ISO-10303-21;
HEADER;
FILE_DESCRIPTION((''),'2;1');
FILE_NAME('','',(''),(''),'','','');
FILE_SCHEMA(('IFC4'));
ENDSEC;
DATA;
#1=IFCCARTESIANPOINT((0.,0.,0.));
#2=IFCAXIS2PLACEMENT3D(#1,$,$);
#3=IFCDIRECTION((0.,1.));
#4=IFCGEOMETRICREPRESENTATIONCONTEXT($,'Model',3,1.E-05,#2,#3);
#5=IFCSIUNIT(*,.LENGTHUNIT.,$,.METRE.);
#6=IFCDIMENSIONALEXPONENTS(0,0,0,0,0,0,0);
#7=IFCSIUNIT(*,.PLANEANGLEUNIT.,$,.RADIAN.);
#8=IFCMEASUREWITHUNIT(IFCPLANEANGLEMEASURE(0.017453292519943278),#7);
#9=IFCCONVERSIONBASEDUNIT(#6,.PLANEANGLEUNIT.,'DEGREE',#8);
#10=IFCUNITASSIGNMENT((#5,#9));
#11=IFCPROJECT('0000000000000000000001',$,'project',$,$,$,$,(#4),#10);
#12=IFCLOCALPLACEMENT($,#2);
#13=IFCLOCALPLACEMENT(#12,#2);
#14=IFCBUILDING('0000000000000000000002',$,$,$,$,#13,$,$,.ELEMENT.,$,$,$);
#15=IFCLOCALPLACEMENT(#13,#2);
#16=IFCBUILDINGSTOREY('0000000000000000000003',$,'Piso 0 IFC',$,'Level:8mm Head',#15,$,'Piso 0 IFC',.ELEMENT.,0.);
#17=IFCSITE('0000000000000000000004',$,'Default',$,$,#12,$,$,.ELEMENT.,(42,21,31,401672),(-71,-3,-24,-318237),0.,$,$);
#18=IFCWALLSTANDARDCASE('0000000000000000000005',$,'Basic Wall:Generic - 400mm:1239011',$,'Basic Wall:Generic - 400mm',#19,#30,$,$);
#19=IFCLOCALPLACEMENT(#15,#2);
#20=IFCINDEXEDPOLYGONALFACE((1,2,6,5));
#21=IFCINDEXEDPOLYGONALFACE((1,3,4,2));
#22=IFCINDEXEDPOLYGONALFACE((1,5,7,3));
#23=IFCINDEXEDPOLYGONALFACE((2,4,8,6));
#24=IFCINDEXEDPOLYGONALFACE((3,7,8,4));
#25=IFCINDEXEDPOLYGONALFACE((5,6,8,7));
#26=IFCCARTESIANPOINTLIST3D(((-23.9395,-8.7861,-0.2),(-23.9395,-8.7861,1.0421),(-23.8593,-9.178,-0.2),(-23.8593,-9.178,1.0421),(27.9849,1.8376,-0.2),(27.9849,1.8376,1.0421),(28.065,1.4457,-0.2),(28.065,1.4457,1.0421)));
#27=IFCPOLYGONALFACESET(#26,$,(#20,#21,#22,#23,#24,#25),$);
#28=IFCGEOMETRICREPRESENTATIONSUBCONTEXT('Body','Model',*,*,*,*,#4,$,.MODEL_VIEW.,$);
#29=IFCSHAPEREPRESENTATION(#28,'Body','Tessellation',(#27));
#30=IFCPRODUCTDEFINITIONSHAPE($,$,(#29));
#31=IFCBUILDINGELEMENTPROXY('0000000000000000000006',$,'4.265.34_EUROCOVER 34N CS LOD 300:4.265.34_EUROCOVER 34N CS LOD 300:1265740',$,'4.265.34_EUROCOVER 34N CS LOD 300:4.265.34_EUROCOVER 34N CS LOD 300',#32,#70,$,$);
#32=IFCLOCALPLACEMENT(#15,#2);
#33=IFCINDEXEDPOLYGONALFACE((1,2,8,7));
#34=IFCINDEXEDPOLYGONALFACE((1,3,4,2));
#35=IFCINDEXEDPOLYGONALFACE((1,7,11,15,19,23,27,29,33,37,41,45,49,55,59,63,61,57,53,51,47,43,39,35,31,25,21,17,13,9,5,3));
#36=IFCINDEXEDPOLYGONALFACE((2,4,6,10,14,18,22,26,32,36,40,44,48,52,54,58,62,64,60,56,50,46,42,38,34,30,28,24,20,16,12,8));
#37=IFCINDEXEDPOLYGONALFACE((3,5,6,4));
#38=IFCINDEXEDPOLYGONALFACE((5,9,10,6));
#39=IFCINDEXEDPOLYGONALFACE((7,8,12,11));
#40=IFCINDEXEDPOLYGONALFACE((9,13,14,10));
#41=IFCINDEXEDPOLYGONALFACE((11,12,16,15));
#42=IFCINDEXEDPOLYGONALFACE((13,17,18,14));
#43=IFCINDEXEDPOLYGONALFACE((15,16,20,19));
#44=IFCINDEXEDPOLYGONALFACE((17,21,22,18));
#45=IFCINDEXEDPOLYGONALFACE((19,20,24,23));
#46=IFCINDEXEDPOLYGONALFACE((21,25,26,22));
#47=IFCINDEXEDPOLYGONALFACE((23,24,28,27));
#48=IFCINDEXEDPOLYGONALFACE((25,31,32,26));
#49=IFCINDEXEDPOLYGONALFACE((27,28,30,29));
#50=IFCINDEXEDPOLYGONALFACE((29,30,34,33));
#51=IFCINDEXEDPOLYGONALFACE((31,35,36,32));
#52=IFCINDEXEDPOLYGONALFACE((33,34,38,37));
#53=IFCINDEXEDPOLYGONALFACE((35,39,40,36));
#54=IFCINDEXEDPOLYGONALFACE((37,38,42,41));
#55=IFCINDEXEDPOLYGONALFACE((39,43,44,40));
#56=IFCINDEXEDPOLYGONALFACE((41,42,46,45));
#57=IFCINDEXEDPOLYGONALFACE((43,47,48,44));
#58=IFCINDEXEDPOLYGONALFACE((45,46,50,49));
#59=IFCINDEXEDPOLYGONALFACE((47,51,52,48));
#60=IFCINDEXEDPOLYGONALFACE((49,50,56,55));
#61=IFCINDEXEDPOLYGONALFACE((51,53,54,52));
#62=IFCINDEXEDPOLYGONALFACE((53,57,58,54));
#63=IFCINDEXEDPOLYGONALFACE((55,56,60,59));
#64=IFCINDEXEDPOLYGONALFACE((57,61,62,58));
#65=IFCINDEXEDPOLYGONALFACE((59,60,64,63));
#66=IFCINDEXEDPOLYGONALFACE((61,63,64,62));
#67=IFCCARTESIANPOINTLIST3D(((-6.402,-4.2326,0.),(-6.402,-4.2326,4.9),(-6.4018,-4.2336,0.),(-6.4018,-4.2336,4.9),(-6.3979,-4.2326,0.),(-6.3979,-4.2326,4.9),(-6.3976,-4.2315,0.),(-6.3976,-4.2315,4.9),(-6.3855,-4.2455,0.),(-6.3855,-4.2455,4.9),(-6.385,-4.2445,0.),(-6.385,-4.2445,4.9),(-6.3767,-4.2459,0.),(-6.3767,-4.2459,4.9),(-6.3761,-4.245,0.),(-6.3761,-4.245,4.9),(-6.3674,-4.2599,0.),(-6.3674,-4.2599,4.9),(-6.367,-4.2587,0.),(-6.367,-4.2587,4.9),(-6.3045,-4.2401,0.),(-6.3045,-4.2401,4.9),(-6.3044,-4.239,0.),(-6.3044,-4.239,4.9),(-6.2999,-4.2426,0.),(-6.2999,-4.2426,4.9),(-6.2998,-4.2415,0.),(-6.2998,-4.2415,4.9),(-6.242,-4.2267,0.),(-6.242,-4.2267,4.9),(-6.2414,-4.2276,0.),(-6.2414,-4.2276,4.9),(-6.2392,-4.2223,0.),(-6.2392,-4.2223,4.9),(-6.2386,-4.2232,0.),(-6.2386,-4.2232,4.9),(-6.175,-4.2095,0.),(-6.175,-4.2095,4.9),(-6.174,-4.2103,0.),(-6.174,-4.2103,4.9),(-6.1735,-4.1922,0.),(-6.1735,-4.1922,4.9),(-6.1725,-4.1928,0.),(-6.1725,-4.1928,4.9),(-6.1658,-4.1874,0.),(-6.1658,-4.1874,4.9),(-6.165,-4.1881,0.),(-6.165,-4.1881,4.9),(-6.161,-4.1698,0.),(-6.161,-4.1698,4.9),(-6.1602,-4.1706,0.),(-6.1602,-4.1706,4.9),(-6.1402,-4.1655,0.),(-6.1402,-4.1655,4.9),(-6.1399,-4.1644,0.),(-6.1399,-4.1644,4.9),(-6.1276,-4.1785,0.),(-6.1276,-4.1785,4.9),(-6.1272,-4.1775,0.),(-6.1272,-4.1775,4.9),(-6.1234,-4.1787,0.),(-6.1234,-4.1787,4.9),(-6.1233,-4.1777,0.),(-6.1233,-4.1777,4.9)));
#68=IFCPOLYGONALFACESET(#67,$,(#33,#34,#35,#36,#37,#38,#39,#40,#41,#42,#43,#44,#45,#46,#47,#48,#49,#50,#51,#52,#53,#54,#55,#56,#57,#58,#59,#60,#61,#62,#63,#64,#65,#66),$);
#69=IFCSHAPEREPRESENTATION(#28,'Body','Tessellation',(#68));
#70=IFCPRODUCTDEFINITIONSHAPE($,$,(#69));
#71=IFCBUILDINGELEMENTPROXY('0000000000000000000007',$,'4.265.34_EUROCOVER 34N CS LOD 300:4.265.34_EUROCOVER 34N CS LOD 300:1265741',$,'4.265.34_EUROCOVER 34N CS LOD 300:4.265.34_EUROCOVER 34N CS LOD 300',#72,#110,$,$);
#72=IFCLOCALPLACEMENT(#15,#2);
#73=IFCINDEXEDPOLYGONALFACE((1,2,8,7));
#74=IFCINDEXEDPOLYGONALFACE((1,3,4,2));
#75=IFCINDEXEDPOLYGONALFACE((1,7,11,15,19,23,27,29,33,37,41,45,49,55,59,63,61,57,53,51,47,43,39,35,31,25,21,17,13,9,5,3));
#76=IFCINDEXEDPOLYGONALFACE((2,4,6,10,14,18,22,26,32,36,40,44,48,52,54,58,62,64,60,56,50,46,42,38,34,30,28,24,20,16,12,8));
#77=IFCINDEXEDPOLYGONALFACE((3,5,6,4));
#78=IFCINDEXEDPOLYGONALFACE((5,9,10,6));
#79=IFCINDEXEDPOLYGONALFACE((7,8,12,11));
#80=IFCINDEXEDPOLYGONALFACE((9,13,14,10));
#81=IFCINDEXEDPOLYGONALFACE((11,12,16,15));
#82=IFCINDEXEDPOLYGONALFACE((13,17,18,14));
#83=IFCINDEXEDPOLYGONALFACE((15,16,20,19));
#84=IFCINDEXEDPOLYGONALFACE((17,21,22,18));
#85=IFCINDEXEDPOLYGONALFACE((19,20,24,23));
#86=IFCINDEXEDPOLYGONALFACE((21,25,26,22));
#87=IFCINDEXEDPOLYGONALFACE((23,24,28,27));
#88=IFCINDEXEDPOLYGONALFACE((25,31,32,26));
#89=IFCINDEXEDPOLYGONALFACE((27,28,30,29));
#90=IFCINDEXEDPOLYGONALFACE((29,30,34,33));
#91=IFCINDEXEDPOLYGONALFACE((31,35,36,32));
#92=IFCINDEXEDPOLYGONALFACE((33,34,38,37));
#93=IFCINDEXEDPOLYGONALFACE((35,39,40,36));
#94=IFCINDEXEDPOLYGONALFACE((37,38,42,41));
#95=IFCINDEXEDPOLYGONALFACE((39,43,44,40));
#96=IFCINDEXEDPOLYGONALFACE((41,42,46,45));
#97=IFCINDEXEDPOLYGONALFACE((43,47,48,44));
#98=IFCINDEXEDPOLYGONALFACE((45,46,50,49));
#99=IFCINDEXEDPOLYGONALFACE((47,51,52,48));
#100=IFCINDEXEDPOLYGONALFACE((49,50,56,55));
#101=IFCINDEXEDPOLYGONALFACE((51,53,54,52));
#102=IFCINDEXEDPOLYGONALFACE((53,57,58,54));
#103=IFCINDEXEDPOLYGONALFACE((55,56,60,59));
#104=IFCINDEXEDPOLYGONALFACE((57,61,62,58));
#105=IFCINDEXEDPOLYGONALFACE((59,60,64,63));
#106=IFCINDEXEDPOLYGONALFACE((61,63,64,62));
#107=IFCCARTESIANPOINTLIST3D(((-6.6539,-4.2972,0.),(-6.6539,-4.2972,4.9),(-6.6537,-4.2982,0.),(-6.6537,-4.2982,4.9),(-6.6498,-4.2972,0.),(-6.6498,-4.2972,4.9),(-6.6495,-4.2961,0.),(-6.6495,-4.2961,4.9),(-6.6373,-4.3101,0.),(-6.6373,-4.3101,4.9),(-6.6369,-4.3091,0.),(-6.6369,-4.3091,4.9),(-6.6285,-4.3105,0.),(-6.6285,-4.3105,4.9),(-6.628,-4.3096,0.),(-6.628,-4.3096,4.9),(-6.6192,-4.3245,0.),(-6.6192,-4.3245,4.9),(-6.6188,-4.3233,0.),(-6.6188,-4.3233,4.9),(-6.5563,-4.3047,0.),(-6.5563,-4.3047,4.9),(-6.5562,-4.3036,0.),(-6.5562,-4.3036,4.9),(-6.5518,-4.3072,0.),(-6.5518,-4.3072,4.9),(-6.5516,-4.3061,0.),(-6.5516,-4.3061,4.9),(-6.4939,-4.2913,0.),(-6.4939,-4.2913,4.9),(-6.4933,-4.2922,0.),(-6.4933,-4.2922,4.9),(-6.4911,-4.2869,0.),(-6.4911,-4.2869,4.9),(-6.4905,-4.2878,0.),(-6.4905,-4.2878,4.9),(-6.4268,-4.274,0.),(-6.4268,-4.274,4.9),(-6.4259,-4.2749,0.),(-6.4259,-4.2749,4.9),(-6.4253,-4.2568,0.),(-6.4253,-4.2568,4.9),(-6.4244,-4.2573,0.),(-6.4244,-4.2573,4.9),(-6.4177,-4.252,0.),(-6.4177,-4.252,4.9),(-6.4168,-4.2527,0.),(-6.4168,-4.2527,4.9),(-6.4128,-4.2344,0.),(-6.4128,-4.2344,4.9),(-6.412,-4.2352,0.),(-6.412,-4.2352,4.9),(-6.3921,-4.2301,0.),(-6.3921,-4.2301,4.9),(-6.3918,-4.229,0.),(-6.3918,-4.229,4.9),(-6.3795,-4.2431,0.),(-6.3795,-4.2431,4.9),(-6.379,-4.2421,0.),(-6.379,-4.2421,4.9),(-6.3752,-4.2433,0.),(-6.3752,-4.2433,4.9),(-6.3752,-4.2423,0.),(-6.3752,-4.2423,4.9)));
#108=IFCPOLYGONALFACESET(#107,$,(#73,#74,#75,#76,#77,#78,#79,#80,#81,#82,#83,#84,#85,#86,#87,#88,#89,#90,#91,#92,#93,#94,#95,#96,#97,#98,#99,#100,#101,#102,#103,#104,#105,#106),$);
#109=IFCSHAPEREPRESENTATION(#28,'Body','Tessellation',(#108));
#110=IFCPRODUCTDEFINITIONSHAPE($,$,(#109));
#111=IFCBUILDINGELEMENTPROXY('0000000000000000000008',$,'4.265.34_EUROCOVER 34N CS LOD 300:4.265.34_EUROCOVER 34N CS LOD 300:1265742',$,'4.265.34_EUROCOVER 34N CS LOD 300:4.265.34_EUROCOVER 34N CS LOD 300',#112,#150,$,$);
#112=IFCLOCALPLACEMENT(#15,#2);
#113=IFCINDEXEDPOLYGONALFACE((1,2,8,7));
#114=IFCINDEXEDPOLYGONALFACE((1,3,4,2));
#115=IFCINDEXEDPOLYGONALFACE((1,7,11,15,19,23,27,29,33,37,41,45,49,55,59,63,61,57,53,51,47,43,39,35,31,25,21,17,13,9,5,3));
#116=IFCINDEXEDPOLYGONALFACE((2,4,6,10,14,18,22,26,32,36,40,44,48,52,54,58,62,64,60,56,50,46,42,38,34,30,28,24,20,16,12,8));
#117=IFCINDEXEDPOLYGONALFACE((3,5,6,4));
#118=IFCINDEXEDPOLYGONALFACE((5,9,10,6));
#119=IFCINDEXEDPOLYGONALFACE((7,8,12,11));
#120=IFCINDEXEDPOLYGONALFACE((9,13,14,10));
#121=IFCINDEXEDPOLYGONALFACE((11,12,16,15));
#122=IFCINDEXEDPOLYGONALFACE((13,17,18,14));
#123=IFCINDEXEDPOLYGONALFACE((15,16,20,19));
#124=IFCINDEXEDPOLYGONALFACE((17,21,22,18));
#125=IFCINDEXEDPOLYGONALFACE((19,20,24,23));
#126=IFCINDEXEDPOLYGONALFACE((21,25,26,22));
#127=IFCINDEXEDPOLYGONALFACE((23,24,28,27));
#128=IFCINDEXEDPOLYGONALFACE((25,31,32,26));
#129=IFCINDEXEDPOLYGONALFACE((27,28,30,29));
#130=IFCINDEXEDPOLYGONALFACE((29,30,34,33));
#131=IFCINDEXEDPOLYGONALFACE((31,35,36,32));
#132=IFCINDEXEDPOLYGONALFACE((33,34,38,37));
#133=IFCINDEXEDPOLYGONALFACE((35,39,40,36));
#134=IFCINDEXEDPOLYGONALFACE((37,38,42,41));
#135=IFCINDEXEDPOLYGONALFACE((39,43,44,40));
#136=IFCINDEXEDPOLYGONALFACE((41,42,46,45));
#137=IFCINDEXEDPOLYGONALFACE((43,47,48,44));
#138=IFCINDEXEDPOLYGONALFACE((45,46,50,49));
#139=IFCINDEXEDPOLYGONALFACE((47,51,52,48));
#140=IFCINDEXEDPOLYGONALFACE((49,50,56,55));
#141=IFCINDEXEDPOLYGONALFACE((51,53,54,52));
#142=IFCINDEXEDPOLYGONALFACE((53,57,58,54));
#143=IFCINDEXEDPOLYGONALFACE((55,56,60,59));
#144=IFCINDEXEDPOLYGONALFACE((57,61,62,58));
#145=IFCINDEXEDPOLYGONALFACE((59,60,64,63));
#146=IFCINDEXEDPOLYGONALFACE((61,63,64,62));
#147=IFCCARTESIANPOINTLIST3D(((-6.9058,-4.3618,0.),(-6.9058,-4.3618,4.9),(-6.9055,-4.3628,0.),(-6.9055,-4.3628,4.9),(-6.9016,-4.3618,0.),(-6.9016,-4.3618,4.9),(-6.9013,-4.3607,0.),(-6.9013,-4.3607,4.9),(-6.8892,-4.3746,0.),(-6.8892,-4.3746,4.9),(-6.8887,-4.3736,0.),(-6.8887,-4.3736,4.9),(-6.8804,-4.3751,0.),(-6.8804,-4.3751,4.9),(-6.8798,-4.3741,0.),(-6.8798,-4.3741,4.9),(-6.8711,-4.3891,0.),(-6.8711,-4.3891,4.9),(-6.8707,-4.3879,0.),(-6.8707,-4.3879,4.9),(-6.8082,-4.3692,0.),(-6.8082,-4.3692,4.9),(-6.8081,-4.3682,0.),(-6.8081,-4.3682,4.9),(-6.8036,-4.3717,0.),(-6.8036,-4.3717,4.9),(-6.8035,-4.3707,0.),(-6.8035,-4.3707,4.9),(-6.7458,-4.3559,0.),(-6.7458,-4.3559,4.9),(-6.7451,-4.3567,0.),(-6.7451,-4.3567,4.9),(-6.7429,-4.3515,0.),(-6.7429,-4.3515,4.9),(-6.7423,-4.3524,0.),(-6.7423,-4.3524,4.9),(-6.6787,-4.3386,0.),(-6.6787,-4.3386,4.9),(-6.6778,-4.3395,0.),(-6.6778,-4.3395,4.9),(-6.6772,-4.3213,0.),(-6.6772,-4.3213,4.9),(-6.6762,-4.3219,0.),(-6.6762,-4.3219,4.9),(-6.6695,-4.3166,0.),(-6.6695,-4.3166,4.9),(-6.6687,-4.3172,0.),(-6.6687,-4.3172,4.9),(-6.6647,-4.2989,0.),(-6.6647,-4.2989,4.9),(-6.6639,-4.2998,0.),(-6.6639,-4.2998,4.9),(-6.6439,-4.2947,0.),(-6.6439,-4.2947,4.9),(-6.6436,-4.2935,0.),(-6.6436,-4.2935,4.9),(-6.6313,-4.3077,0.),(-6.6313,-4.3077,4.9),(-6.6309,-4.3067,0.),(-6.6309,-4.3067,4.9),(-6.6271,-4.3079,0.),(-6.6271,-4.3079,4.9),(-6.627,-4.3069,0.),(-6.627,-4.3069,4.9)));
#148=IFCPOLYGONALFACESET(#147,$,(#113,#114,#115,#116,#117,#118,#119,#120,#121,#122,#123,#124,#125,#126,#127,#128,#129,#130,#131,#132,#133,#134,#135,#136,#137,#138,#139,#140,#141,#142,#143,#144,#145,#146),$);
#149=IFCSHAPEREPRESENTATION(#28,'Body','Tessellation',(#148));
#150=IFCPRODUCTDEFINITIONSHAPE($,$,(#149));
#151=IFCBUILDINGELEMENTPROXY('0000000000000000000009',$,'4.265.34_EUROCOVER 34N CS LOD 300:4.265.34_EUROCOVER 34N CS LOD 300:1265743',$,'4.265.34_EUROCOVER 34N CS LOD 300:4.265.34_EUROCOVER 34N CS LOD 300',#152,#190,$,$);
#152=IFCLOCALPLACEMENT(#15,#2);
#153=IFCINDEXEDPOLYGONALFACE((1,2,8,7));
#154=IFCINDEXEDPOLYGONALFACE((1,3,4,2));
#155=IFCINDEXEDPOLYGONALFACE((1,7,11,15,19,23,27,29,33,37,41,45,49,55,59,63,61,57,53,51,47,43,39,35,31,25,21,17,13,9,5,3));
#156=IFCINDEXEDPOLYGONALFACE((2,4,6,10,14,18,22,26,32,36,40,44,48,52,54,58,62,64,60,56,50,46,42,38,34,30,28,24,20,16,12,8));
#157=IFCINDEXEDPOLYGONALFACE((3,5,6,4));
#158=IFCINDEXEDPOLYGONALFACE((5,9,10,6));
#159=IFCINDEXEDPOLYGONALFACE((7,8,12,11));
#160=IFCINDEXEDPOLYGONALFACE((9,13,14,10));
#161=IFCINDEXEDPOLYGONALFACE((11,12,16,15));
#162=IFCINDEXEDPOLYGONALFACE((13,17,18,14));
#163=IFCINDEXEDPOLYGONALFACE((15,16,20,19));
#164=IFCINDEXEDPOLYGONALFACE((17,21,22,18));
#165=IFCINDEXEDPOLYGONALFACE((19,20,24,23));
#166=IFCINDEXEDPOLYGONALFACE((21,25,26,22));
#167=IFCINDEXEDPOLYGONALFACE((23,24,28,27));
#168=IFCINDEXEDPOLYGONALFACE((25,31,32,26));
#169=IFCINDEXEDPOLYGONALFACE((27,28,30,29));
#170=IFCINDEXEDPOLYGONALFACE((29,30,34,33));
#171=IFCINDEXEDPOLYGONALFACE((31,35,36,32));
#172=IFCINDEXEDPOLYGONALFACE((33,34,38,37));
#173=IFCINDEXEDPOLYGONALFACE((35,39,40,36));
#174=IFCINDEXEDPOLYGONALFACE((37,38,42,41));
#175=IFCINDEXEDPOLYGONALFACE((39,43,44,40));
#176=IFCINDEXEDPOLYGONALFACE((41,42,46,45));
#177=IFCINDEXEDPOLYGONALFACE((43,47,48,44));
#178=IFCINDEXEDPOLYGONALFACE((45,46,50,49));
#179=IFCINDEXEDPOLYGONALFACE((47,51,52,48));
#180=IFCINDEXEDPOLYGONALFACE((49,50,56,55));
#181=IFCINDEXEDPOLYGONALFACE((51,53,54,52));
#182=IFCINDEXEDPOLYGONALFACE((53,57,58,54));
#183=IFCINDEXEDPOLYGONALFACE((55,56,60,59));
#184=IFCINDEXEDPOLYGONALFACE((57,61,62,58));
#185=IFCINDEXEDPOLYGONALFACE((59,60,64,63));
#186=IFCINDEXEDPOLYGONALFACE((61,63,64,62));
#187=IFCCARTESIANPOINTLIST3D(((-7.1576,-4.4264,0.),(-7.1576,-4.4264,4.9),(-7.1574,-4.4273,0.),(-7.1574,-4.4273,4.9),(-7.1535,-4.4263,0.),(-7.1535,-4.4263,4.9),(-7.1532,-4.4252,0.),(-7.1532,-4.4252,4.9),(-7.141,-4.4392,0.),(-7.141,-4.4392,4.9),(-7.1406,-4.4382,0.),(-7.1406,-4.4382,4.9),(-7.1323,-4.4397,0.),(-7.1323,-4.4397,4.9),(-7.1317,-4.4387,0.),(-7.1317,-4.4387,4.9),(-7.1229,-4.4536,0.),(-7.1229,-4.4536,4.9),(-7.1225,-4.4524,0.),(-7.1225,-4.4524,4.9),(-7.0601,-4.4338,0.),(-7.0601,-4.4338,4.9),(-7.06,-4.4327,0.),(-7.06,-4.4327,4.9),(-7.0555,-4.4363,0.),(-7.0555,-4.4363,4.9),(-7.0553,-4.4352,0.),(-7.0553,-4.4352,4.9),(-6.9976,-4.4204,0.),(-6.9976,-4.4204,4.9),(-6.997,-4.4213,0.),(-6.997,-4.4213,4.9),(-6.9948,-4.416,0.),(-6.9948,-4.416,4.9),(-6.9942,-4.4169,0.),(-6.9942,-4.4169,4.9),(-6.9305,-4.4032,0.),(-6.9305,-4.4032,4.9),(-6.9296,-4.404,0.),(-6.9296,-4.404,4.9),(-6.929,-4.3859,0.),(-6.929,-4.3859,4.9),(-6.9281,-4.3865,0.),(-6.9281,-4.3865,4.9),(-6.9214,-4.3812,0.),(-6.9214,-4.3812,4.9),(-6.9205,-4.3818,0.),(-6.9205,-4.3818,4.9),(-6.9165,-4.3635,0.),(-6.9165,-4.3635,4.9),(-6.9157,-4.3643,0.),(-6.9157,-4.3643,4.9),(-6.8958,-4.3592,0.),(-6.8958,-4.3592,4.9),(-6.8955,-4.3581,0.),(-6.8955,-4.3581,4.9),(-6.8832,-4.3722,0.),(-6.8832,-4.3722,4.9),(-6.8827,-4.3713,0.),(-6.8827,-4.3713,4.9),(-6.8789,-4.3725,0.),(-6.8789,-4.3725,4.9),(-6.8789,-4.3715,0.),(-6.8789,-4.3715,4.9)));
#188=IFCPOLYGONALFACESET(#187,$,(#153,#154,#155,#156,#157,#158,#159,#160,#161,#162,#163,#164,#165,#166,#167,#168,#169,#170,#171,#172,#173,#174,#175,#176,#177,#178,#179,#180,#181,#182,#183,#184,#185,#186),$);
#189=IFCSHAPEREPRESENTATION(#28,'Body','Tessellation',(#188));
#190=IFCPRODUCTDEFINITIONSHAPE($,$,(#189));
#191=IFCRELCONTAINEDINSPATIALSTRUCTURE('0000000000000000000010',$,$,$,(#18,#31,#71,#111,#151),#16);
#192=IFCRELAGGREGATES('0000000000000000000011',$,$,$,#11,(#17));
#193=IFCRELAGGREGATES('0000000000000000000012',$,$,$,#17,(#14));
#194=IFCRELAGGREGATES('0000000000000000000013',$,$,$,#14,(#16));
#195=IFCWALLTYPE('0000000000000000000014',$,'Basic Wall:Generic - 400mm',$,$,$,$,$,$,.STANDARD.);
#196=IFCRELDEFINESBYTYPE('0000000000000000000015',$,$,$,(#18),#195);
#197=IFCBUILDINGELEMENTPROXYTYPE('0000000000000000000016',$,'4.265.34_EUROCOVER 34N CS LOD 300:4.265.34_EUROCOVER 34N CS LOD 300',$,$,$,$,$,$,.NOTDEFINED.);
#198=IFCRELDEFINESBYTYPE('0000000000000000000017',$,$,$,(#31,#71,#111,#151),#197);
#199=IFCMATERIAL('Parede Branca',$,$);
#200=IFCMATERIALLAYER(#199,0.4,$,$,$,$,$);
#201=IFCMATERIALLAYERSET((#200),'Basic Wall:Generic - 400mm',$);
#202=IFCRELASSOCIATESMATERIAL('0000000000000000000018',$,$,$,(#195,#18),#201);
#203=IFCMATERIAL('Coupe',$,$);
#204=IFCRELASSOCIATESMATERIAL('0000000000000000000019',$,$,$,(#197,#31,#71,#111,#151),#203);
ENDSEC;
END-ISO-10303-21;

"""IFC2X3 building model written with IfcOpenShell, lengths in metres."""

from ifc_helpers import new_model, entity, si_unit, converted_unit, direction, frame, frame_2d, origin, place, context, subcontext, project, spatial, polyline, rectangle, outline, extrude, source, transform, mapped, material, layer, layer_set, layer_usage, type_object, type_shapes, element, save


model = new_model("IFC2X3")

# Units and contexts
model_context = context("Model", 3, precision=1e-05, world=origin(), true_north=direction((0.0, 1.0)))
body_context = subcontext(model_context, "Body", "Model", "MODEL_VIEW")
ifc_project = project(units=[si_unit("LENGTHUNIT", "METRE"), converted_unit("PLANEANGLEUNIT", "DEGREE", entity("IfcPlaneAngleMeasure", 0.017453292519943278), si_unit("PLANEANGLEUNIT", "RADIAN"), dimensions=[0, 0, 0, 0, 0, 0, 0])], contexts=[model_context])

# Site, building, storey
site_placement = place(None, origin())
site = spatial("IfcSite", under=ifc_project, at=site_placement, Name="Default", CompositionType="ELEMENT", RefLatitude=(42, 21, 31, 401672), RefLongitude=(-71, -3, -24, -318237), RefElevation=0.0)
building_placement = place(site_placement, origin())
building = spatial("IfcBuilding", under=site, at=building_placement, CompositionType="ELEMENT")
storey_placement = place(building_placement, origin())
storey = spatial("IfcBuildingStorey", under=building, at=storey_placement, Name="Piso 0 IFC", ObjectType="Level:8mm Head", LongName="Piso 0 IFC", CompositionType="ELEMENT", Elevation=0.0)

# Wall
ifc_material_1 = material(Name="Parede Branca")
ifc_layer_1 = layer(ifc_material_1, 0.4)
ifc_layer_set_1 = layer_set([ifc_layer_1], Name="Basic Wall:Generic - 400mm")
ifc_layer_usage_1 = layer_usage(ifc_layer_set_1, "AXIS2", "NEGATIVE", 0.2)
wall_type_1 = type_object("IfcWallType", Name="Basic Wall:Generic - 400mm", PredefinedType="STANDARD", material=ifc_layer_set_1)
wall_1_placement = place(storey_placement, frame((-23.8994, -8.982, -0.2), z_axis=(0.0, 0.0, 1.0), x_axis=(0.979705, 0.200447, 0.0)))
element("IfcWallStandardCase", 1, at=wall_1_placement, inside=storey, type_object=wall_type_1, material=ifc_layer_usage_1, Name="Basic Wall:Generic - 400mm:1239011", ObjectType="Basic Wall:Generic - 400mm", context=body_context, shape_type="SweptSolid", body=[
    extrude(rectangle(XDim=53.0, YDim=0.4, at=frame_2d((26.5, 0.0), x_axis=(-1.0, 0.0))), origin(), (0.0, 0.0, 1.0), 1.2421),
])

# Building element proxies
ifc_material_2 = material(Name="Coupe")
building_element_proxy_type = type_object("IfcBuildingElementProxyType", Name="4.265.34_EUROCOVER 34N CS LOD 300:4.265.34_EUROCOVER 34N CS LOD 300", PredefinedType="NOTDEFINED", material=ifc_material_2)
shared_shape = source(origin(), body_context, "Body", "SweptSolid", [
    extrude(outline(polyline([(0.0449, 0.1162), (0.063, 0.1162), (0.0661, 0.1191), (0.0654, 0.1198), (0.0626, 0.1172), (0.0443, 0.1172), (0.0335, 0.0983), (0.0428, 0.0826), (0.0409, 0.0738), (0.0522, 0.0606), (0.0167, 0.0056), (0.0179, 0.0005), (-0.0117, -0.0512), (-0.0167, -0.0528), (-0.0462, -0.1114), (-0.0624, -0.1084), (-0.069, -0.1145), (-0.0871, -0.1145), (-0.0893, -0.1184), (-0.0885, -0.1189), (-0.0865, -0.1155), (-0.0686, -0.1155), (-0.0621, -0.1095), (-0.0456, -0.1125), (-0.016, -0.0536), (-0.0111, -0.0521), (0.0189, 0.0004), (0.0177, 0.0054), (0.0535, 0.0607), (0.0419, 0.074), (0.0438, 0.0827), (0.0347, 0.0983), (0.0449, 0.1162)])), frame((-0.0171, -0.0163, 0.0), z_axis=(0.0, 0.0, 1.0), x_axis=(-0.496574, 0.867994, 0.0)), (0.0, 0.0, 1.0), 4.9),
])
type_shapes(building_element_proxy_type, [shared_shape])
for number, where, z_axis, x_axis, name in (
    (2, (-6.2674, -4.2343, 0.0), (0.0, 0.0, 1.0), (-0.968666, -0.248367, 0.0), "4.265.34_EUROCOVER 34N CS LOD 300:4.265.34_EUROCOVER 34N CS LOD 300:1265740"),
    (3, (-6.5193, -4.2989, 0.0), (0.0, 0.0, 1.0), (-0.968666, -0.248367, 0.0), "4.265.34_EUROCOVER 34N CS LOD 300:4.265.34_EUROCOVER 34N CS LOD 300:1265741"),
    (4, (-6.7711, -4.3634, 0.0), (0.0, 0.0, 1.0), (-0.968666, -0.248367, 0.0), "4.265.34_EUROCOVER 34N CS LOD 300:4.265.34_EUROCOVER 34N CS LOD 300:1265742"),
    (5, (-7.023, -4.428, 0.0), (0.0, 0.0, 1.0), (-0.968666, -0.248367, 0.0), "4.265.34_EUROCOVER 34N CS LOD 300:4.265.34_EUROCOVER 34N CS LOD 300:1265743"),
):
    element("IfcBuildingElementProxy", number, at=place(storey_placement, frame(where, z_axis=z_axis, x_axis=x_axis)), inside=storey, type_object=building_element_proxy_type, material=ifc_material_2, Name=name, ObjectType="4.265.34_EUROCOVER 34N CS LOD 300:4.265.34_EUROCOVER 34N CS LOD 300", context=body_context, shape_type="MappedRepresentation", body=[
        mapped(shared_shape, transform((0.0, 0.0, 0.0), scale=1.0)),
    ])

save(model, "model.ifc")
